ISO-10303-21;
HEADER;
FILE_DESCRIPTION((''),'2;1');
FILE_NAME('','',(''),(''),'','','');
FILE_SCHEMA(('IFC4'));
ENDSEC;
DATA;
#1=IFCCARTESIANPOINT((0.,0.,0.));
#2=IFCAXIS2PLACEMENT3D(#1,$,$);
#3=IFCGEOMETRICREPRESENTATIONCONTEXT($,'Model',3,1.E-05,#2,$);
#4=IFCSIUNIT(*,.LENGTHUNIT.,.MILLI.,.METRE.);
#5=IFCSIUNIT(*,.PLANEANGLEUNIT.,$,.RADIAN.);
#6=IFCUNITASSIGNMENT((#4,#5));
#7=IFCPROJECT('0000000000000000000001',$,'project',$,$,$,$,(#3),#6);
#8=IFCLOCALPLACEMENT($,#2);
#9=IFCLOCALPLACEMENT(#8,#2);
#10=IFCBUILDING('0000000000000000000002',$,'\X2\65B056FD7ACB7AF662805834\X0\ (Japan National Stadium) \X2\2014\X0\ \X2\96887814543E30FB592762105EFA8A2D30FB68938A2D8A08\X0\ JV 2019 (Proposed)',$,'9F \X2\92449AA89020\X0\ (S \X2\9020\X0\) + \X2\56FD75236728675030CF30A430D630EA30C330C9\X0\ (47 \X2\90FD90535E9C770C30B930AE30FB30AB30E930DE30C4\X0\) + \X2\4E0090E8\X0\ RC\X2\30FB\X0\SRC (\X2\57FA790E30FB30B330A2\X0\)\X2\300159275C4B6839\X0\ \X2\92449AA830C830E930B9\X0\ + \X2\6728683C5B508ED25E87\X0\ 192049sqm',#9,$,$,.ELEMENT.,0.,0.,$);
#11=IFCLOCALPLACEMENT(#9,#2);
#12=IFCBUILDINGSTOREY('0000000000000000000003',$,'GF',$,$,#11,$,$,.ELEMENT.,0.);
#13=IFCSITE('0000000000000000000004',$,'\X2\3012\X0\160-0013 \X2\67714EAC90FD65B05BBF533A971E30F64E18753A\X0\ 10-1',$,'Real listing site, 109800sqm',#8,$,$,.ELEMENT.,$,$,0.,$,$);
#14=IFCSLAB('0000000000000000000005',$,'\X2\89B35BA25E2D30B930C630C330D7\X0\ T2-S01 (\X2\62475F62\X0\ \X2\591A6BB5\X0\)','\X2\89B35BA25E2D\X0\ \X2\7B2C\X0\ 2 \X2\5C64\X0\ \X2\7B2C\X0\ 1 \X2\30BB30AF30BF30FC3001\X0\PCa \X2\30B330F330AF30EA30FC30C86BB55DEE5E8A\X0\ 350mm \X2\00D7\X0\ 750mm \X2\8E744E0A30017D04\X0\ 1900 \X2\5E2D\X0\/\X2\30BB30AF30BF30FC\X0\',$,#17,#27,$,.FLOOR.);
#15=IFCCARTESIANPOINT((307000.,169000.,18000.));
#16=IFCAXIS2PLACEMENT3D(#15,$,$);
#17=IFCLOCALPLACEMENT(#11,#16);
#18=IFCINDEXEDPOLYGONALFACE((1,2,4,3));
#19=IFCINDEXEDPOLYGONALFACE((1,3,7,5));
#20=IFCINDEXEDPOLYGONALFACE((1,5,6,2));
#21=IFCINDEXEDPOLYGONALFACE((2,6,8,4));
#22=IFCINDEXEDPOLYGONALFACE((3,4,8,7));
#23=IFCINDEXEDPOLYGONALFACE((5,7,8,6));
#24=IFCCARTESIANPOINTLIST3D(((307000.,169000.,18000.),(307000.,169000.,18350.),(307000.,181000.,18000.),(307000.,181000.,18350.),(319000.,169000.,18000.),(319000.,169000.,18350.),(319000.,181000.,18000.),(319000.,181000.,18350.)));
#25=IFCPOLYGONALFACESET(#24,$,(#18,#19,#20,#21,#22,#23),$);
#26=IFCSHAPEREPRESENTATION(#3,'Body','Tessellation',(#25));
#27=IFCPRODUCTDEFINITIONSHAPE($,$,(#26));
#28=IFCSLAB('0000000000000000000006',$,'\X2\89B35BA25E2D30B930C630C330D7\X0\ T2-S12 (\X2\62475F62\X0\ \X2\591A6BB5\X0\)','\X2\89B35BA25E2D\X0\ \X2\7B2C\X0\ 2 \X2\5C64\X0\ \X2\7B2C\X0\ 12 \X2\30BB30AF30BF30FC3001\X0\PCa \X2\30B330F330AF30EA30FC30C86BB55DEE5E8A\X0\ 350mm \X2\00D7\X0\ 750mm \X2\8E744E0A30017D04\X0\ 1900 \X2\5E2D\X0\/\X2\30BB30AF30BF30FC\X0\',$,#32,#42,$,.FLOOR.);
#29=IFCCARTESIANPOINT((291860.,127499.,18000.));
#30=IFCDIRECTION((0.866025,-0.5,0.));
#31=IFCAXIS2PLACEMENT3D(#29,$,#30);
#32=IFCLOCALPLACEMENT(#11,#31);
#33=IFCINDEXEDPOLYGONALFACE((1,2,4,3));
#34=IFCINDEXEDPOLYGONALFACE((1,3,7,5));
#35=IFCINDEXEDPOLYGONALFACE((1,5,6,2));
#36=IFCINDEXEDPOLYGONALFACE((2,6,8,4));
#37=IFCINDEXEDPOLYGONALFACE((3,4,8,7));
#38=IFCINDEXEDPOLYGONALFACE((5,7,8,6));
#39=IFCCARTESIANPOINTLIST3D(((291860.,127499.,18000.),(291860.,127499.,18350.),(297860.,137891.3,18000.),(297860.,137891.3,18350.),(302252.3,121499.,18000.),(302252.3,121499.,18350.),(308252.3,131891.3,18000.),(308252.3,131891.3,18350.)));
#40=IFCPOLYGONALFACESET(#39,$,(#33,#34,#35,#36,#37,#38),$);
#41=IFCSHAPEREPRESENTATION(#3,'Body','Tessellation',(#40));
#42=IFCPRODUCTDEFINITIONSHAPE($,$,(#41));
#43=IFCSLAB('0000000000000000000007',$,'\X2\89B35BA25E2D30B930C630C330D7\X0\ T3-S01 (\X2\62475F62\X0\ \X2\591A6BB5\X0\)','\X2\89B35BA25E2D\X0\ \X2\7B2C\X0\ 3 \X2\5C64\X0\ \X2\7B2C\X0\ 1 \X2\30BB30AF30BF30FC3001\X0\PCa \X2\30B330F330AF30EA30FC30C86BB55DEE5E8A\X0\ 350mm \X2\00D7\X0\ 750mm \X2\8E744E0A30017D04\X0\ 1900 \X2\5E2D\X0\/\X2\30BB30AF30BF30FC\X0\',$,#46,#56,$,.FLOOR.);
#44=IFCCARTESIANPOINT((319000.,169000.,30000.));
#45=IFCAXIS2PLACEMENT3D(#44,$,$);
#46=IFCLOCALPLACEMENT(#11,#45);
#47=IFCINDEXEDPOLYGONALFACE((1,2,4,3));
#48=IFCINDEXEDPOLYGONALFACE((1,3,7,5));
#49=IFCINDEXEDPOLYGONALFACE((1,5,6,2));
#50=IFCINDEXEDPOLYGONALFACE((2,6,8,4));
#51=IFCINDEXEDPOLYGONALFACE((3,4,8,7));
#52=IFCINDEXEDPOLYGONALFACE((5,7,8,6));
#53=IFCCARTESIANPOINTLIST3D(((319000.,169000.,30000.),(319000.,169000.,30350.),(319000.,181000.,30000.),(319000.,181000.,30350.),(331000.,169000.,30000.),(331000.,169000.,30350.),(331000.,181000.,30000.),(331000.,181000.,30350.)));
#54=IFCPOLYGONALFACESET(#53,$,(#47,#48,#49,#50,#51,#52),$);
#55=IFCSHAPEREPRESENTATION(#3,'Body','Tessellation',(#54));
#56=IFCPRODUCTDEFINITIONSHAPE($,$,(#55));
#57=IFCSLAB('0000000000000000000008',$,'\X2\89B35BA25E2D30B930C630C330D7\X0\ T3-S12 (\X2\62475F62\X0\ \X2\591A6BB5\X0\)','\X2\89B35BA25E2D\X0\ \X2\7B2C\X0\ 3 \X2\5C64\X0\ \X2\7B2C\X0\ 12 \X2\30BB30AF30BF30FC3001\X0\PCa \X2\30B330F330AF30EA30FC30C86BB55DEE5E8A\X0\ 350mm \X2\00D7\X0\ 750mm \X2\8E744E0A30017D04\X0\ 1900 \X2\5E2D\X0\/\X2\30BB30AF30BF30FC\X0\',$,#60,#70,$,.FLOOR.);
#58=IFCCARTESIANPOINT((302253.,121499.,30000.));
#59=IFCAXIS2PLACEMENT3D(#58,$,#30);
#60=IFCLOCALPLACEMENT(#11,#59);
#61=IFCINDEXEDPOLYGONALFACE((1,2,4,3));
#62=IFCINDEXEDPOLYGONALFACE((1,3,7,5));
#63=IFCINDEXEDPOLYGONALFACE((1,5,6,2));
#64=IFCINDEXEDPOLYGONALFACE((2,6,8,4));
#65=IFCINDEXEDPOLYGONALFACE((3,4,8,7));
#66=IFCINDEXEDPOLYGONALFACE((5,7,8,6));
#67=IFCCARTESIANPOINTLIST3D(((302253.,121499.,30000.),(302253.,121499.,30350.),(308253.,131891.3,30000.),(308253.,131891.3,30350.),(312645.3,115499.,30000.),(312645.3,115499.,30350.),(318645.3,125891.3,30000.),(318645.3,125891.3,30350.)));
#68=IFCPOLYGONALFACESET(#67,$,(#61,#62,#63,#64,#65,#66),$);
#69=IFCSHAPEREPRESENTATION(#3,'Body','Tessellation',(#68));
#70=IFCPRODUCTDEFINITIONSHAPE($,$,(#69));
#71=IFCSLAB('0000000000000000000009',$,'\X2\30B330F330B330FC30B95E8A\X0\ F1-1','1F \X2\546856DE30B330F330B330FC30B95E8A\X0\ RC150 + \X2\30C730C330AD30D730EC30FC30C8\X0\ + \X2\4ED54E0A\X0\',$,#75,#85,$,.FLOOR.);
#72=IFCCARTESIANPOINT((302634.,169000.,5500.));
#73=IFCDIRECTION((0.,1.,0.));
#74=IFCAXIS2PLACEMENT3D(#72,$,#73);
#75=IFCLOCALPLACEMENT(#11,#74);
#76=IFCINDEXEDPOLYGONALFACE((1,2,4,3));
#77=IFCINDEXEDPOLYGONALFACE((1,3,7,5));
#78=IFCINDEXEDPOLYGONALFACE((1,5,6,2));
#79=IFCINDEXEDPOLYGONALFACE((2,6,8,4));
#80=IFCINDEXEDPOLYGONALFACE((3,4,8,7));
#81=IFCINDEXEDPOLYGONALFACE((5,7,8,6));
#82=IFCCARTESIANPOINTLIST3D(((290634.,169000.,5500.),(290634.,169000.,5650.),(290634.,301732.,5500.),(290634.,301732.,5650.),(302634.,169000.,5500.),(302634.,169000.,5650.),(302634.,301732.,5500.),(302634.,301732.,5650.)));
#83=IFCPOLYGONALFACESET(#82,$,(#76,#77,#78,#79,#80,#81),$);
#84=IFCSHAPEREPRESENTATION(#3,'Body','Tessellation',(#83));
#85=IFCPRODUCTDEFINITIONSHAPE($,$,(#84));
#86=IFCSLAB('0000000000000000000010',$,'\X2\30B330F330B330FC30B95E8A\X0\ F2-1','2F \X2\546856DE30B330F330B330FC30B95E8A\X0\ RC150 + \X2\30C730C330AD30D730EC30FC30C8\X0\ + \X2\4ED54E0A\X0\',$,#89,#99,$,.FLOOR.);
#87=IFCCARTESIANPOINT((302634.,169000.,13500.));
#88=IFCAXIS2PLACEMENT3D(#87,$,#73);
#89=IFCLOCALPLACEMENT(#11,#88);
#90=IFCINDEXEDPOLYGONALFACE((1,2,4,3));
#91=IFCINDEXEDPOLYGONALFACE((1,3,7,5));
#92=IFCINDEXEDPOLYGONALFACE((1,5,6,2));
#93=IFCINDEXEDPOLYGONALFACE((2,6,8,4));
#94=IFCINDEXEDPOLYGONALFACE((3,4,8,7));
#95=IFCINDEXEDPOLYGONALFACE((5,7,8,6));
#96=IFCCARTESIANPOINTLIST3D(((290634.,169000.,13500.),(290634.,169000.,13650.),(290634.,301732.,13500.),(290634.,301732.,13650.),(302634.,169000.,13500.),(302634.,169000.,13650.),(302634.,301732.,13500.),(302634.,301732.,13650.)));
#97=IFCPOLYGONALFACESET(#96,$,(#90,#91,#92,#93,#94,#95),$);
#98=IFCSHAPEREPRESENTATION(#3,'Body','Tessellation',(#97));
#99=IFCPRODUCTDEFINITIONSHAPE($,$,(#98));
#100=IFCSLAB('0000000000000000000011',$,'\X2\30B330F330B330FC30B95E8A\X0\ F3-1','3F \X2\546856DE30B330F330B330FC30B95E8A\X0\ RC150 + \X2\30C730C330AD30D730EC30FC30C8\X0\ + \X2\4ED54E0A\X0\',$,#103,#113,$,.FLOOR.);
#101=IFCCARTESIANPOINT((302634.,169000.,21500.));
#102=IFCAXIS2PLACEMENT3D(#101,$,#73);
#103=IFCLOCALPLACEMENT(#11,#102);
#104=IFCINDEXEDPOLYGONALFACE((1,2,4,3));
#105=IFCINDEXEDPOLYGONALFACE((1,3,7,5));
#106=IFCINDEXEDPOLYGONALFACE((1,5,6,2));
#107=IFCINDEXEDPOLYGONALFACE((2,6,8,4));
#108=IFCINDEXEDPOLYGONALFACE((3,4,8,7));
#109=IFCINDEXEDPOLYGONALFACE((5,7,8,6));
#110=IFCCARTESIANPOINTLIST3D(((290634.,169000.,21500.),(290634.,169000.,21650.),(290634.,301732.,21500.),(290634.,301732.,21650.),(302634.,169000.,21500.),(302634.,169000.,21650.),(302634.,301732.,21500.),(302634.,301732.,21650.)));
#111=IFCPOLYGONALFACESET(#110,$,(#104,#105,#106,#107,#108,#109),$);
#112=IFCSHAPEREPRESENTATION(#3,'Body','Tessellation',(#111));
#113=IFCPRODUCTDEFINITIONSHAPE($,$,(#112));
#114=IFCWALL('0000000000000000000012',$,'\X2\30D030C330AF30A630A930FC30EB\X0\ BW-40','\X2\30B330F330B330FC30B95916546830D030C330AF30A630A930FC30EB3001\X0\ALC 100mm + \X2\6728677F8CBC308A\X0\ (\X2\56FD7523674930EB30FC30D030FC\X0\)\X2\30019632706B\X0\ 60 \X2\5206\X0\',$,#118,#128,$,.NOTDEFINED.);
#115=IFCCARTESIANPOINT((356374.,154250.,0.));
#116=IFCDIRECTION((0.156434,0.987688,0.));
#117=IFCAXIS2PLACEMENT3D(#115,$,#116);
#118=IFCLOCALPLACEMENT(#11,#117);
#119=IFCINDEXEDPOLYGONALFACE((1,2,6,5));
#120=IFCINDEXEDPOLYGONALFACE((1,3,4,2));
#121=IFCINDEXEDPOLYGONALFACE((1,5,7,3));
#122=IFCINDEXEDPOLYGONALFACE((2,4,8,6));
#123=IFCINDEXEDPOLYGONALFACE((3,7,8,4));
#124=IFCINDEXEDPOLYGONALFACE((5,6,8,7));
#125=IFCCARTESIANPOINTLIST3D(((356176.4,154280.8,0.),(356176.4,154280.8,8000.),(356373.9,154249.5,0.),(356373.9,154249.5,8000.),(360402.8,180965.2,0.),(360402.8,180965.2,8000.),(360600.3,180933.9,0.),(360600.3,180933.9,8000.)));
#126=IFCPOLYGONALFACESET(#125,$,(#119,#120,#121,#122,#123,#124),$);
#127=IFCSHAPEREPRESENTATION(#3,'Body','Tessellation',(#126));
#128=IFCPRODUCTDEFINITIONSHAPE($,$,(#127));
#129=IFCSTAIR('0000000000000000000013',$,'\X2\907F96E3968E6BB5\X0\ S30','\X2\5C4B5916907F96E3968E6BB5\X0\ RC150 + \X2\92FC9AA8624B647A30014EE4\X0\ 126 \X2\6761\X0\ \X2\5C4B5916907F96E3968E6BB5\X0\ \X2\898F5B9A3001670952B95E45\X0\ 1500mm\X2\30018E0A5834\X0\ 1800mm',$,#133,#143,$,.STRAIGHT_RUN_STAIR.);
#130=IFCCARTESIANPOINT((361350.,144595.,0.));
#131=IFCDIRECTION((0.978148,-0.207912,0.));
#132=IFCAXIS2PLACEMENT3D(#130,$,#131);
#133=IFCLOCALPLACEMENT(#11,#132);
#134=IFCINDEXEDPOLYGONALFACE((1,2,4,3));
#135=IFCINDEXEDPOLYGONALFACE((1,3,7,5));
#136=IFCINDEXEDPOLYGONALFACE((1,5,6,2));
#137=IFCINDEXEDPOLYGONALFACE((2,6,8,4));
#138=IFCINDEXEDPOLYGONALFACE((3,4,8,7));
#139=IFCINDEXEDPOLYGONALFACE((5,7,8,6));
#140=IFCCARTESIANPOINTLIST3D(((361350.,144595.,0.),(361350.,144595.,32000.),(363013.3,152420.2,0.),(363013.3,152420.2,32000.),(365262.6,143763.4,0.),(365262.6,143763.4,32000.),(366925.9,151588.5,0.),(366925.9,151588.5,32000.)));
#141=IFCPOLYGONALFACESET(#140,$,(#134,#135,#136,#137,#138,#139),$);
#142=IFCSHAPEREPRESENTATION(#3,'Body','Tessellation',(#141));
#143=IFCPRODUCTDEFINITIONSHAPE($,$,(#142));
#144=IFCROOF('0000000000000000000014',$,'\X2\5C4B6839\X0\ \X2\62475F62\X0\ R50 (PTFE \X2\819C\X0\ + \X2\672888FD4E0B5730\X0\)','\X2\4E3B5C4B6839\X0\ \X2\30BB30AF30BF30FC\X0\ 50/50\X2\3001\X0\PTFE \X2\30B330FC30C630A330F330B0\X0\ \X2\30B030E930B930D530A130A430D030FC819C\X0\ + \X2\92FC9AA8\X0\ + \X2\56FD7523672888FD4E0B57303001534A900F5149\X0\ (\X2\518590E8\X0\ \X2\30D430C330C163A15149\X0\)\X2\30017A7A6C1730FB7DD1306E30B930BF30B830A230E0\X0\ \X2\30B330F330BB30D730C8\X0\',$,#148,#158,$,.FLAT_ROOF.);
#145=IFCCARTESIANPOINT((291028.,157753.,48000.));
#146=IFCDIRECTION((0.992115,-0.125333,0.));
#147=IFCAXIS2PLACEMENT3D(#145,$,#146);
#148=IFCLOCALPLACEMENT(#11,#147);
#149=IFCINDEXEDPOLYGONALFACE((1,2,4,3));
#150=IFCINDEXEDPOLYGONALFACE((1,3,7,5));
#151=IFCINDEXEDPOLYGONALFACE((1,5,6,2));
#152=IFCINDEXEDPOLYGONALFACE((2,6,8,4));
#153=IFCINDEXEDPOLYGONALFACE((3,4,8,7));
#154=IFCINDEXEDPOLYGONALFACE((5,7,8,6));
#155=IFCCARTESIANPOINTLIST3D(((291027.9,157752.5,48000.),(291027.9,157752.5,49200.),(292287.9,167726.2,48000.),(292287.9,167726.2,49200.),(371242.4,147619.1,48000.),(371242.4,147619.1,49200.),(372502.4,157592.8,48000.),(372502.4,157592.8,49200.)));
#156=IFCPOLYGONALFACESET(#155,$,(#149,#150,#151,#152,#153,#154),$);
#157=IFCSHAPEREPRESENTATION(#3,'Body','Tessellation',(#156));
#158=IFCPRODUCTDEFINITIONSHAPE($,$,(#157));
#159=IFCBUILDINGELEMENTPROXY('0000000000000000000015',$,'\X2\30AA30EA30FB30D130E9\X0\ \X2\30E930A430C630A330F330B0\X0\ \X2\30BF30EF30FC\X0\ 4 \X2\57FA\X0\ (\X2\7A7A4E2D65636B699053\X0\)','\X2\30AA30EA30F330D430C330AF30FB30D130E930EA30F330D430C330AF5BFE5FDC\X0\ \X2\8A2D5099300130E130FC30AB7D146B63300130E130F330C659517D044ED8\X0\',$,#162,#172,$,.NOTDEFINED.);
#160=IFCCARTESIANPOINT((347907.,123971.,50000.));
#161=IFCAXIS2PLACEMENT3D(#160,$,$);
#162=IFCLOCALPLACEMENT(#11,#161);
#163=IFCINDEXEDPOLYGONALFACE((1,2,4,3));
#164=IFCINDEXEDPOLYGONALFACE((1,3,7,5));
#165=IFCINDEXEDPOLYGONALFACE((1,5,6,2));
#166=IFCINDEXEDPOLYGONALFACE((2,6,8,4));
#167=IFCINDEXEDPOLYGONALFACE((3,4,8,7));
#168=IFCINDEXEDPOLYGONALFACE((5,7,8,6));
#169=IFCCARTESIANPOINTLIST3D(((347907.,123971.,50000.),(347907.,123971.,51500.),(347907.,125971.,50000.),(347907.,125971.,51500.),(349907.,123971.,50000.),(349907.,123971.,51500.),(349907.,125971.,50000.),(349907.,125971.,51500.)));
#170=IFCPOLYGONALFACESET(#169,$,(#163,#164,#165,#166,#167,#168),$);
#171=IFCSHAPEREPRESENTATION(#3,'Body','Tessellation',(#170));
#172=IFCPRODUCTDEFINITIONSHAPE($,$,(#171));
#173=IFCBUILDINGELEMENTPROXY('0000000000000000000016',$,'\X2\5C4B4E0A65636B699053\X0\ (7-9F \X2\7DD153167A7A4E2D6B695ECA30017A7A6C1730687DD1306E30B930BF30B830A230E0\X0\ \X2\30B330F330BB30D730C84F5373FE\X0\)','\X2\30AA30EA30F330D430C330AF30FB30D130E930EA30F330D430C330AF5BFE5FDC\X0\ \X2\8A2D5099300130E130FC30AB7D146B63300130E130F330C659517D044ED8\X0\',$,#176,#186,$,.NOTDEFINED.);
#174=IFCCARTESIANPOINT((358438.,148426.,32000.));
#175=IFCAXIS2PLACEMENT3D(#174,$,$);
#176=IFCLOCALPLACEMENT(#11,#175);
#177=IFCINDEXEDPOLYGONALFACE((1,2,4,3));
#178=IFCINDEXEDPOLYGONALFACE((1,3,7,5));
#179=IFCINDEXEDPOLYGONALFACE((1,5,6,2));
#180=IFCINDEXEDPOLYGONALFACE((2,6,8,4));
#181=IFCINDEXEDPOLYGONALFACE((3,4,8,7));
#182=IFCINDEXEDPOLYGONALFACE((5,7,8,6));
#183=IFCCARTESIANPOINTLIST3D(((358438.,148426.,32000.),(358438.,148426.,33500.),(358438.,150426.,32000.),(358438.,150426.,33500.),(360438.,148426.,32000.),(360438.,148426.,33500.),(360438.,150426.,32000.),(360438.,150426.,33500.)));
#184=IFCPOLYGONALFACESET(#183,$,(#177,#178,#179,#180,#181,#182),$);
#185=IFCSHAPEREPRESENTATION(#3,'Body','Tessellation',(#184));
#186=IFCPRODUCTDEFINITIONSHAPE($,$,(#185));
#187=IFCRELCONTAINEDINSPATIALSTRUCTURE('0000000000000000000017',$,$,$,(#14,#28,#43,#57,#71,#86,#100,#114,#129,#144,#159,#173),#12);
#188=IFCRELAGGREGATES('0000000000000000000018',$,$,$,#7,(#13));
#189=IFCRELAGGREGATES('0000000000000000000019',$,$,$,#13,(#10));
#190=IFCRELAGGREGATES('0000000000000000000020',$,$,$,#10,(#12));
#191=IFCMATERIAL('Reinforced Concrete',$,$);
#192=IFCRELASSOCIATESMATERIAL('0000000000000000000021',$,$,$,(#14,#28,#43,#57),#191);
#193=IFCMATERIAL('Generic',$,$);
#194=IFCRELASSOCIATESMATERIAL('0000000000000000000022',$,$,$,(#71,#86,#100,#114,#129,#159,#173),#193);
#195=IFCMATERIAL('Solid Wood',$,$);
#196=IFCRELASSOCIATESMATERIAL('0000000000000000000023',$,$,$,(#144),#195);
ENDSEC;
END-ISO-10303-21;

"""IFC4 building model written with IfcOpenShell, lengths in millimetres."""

from ifc_helpers import new_model, si_unit, frame, frame_2d, origin, place, context, project, spatial, rectangle, extrude, material, element, save


model = new_model("IFC4")

# Units and contexts
model_context = context("Model", 3, precision=1e-05, world=origin())
ifc_project = project(units=[si_unit("LENGTHUNIT", "METRE", prefix="MILLI"), si_unit("PLANEANGLEUNIT", "RADIAN")], contexts=[model_context])

# Site, building, storey
site_placement = place(None, origin())
site = spatial("IfcSite", under=ifc_project, at=site_placement, Name="〒160-0013 東京都新宿区霞ヶ丘町 10-1", ObjectType="Real listing site, 109800sqm", CompositionType="ELEMENT", RefElevation=0.0)
building_placement = place(site_placement, origin())
building = spatial("IfcBuilding", under=site, at=building_placement, Name="新国立競技場 (Japan National Stadium) — 隈研吾・大成建設・梓設計 JV 2019 (Proposed)", ObjectType="9F 鉄骨造 (S 造) + 国産木材ハイブリッド (47 都道府県スギ・カラマツ) + 一部 RC・SRC (基礎・コア)、大屋根 鉄骨トラス + 木格子軒庇 192049sqm", CompositionType="ELEMENT", ElevationOfRefHeight=0.0, ElevationOfTerrain=0.0)
storey_placement = place(building_placement, origin())
storey = spatial("IfcBuildingStorey", under=building, at=storey_placement, Name="GF", CompositionType="ELEMENT", Elevation=0.0)

# Shared definitions
ifc_material_1 = material(Name="Reinforced Concrete")

# Shared definitions
ifc_material_2 = material(Name="Generic")

# Shared definitions
ifc_material_3 = material(Name="Solid Wood")

# Slabs
slab_1_placement = place(storey_placement, frame((307000.0, 169000.0, 18000.0)))
element("IfcSlab", 1, at=slab_1_placement, inside=storey, material=ifc_material_1, Name="観客席ステップ T2-S01 (扇形 多段)", Description="観客席 第 2 層 第 1 セクター、PCa コンクリート段差床 350mm × 750mm 蹴上、約 1900 席/セクター", PredefinedType="FLOOR", context=model_context, shape_type="SweptSolid", body=[
    extrude(rectangle(XDim=12000.0, YDim=12000.0, at=frame_2d((6000.0, 6000.0))), frame((307000.0, 169000.0, 18000.0)), (0.0, 0.0, 1.0), 350.0),
])
slab_2_placement = place(storey_placement, frame((291860.0, 127499.0, 18000.0), x_axis=(0.866025, -0.5, 0.0)))
element("IfcSlab", 2, at=slab_2_placement, inside=storey, material=ifc_material_1, Name="観客席ステップ T2-S12 (扇形 多段)", Description="観客席 第 2 層 第 12 セクター、PCa コンクリート段差床 350mm × 750mm 蹴上、約 1900 席/セクター", PredefinedType="FLOOR", context=model_context, shape_type="SweptSolid", body=[
    extrude(rectangle(XDim=12000.0, YDim=12000.0, at=frame_2d((6000.0, 6000.0))), frame((291860.0, 127499.0, 18000.0), x_axis=(0.866025, -0.5, 0.0)), (0.0, 0.0, 1.0), 350.0),
])
slab_3_placement = place(storey_placement, frame((319000.0, 169000.0, 30000.0)))
element("IfcSlab", 3, at=slab_3_placement, inside=storey, material=ifc_material_1, Name="観客席ステップ T3-S01 (扇形 多段)", Description="観客席 第 3 層 第 1 セクター、PCa コンクリート段差床 350mm × 750mm 蹴上、約 1900 席/セクター", PredefinedType="FLOOR", context=model_context, shape_type="SweptSolid", body=[
    extrude(rectangle(XDim=12000.0, YDim=12000.0, at=frame_2d((6000.0, 6000.0))), frame((319000.0, 169000.0, 30000.0)), (0.0, 0.0, 1.0), 350.0),
])
slab_4_placement = place(storey_placement, frame((302253.0, 121499.0, 30000.0), x_axis=(0.866025, -0.5, 0.0)))
element("IfcSlab", 4, at=slab_4_placement, inside=storey, material=ifc_material_1, Name="観客席ステップ T3-S12 (扇形 多段)", Description="観客席 第 3 層 第 12 セクター、PCa コンクリート段差床 350mm × 750mm 蹴上、約 1900 席/セクター", PredefinedType="FLOOR", context=model_context, shape_type="SweptSolid", body=[
    extrude(rectangle(XDim=12000.0, YDim=12000.0, at=frame_2d((6000.0, 6000.0))), frame((302253.0, 121499.0, 30000.0), x_axis=(0.866025, -0.5, 0.0)), (0.0, 0.0, 1.0), 350.0),
])
slab_5_placement = place(storey_placement, frame((302634.0, 169000.0, 5500.0), x_axis=(0.0, 1.0, 0.0)))
element("IfcSlab", 5, at=slab_5_placement, inside=storey, material=ifc_material_2, Name="コンコース床 F1-1", Description="1F 周回コンコース床 RC150 + デッキプレート + 仕上", PredefinedType="FLOOR", context=model_context, shape_type="SweptSolid", body=[
    extrude(rectangle(XDim=132732.0, YDim=12000.0, at=frame_2d((66366.0, 6000.0))), frame((302634.0, 169000.0, 5500.0), x_axis=(0.0, 1.0, 0.0)), (0.0, 0.0, 1.0), 150.0),
])
slab_6_placement = place(storey_placement, frame((302634.0, 169000.0, 13500.0), x_axis=(0.0, 1.0, 0.0)))
element("IfcSlab", 6, at=slab_6_placement, inside=storey, material=ifc_material_2, Name="コンコース床 F2-1", Description="2F 周回コンコース床 RC150 + デッキプレート + 仕上", PredefinedType="FLOOR", context=model_context, shape_type="SweptSolid", body=[
    extrude(rectangle(XDim=132732.0, YDim=12000.0, at=frame_2d((66366.0, 6000.0))), frame((302634.0, 169000.0, 13500.0), x_axis=(0.0, 1.0, 0.0)), (0.0, 0.0, 1.0), 150.0),
])
slab_7_placement = place(storey_placement, frame((302634.0, 169000.0, 21500.0), x_axis=(0.0, 1.0, 0.0)))
element("IfcSlab", 7, at=slab_7_placement, inside=storey, material=ifc_material_2, Name="コンコース床 F3-1", Description="3F 周回コンコース床 RC150 + デッキプレート + 仕上", PredefinedType="FLOOR", context=model_context, shape_type="SweptSolid", body=[
    extrude(rectangle(XDim=132732.0, YDim=12000.0, at=frame_2d((66366.0, 6000.0))), frame((302634.0, 169000.0, 21500.0), x_axis=(0.0, 1.0, 0.0)), (0.0, 0.0, 1.0), 150.0),
])

# Wall
wall_1_placement = place(storey_placement, frame((356374.0, 154250.0, 0.0), x_axis=(0.156434, 0.987688, 0.0)))
element("IfcWall", 8, at=wall_1_placement, inside=storey, material=ifc_material_2, Name="バックウォール BW-40", Description="コンコース外周バックウォール、ALC 100mm + 木板貼り (国産杉ルーバー)、防火 60 分", PredefinedType="NOTDEFINED", context=model_context, shape_type="SweptSolid", body=[
    extrude(rectangle(XDim=27017.0, YDim=200.0, at=frame_2d((13508.0, 100.0))), frame((356374.0, 154250.0, 0.0), x_axis=(0.156434, 0.987688, 0.0)), (0.0, 0.0, 1.0), 8000.0),
])

# Stair
stair_placement = place(storey_placement, frame((361350.0, 144595.0, 0.0), x_axis=(0.978148, -0.207912, 0.0)))
element("IfcStair", 9, at=stair_placement, inside=storey, material=ifc_material_2, Name="避難階段 S30", Description="屋外避難階段 RC150 + 鋼骨手摺、令 126 条 屋外避難階段 規定、有効幅 1500mm、踊場 1800mm", PredefinedType="STRAIGHT_RUN_STAIR", context=model_context, shape_type="SweptSolid", body=[
    extrude(rectangle(XDim=4000.0, YDim=8000.0, at=frame_2d((2000.0, 4000.0))), frame((361350.0, 144595.0, 0.0), x_axis=(0.978148, -0.207912, 0.0)), (0.0, 0.0, 1.0), 32000.0),
])

# Roof
roof_1_placement = place(storey_placement, frame((291028.0, 157753.0, 48000.0), x_axis=(0.992115, -0.125333, 0.0)))
element("IfcRoof", 10, at=roof_1_placement, inside=storey, material=ifc_material_3, Name="屋根 扇形 R50 (PTFE 膜 + 木製下地)", Description="主屋根 セクター 50/50、PTFE コーティング グラスファイバー膜 + 鋼骨 + 国産木製下地、半透光 (内部 ピッチ採光)、空気・緑のスタジアム コンセプト", PredefinedType="FLAT_ROOF", context=model_context, shape_type="SweptSolid", body=[
    extrude(rectangle(XDim=80852.0, YDim=10053.0, at=frame_2d((40426.0, 5026.0))), frame((291028.0, 157753.0, 48000.0), x_axis=(0.992115, -0.125333, 0.0)), (0.0, 0.0, 1.0), 1200.0),
])

# Building element proxies
proxy_1_placement = place(storey_placement, frame((347907.0, 123971.0, 50000.0)))
element("IfcBuildingElementProxy", 11, at=proxy_1_placement, inside=storey, material=ifc_material_2, Name="オリ・パラ ライティング タワー 4 基 (空中散歩道)", Description="オリンピック・パラリンピック対応 設備、メーカ純正、メンテ契約付", PredefinedType="NOTDEFINED", context=model_context, shape_type="SweptSolid", body=[
    extrude(rectangle(XDim=2000.0, YDim=2000.0, at=frame_2d((1000.0, 1000.0))), frame((347907.0, 123971.0, 50000.0)), (0.0, 0.0, 1.0), 1500.0),
])
proxy_2_placement = place(storey_placement, frame((358438.0, 148426.0, 32000.0)))
element("IfcBuildingElementProxy", 12, at=proxy_2_placement, inside=storey, material=ifc_material_2, Name="屋上散歩道 (7-9F 緑化空中歩廊、空気と緑のスタジアム コンセプト体現)", Description="オリンピック・パラリンピック対応 設備、メーカ純正、メンテ契約付", PredefinedType="NOTDEFINED", context=model_context, shape_type="SweptSolid", body=[
    extrude(rectangle(XDim=2000.0, YDim=2000.0, at=frame_2d((1000.0, 1000.0))), frame((358438.0, 148426.0, 32000.0)), (0.0, 0.0, 1.0), 1500.0),
])

save(model, "model.ifc")
